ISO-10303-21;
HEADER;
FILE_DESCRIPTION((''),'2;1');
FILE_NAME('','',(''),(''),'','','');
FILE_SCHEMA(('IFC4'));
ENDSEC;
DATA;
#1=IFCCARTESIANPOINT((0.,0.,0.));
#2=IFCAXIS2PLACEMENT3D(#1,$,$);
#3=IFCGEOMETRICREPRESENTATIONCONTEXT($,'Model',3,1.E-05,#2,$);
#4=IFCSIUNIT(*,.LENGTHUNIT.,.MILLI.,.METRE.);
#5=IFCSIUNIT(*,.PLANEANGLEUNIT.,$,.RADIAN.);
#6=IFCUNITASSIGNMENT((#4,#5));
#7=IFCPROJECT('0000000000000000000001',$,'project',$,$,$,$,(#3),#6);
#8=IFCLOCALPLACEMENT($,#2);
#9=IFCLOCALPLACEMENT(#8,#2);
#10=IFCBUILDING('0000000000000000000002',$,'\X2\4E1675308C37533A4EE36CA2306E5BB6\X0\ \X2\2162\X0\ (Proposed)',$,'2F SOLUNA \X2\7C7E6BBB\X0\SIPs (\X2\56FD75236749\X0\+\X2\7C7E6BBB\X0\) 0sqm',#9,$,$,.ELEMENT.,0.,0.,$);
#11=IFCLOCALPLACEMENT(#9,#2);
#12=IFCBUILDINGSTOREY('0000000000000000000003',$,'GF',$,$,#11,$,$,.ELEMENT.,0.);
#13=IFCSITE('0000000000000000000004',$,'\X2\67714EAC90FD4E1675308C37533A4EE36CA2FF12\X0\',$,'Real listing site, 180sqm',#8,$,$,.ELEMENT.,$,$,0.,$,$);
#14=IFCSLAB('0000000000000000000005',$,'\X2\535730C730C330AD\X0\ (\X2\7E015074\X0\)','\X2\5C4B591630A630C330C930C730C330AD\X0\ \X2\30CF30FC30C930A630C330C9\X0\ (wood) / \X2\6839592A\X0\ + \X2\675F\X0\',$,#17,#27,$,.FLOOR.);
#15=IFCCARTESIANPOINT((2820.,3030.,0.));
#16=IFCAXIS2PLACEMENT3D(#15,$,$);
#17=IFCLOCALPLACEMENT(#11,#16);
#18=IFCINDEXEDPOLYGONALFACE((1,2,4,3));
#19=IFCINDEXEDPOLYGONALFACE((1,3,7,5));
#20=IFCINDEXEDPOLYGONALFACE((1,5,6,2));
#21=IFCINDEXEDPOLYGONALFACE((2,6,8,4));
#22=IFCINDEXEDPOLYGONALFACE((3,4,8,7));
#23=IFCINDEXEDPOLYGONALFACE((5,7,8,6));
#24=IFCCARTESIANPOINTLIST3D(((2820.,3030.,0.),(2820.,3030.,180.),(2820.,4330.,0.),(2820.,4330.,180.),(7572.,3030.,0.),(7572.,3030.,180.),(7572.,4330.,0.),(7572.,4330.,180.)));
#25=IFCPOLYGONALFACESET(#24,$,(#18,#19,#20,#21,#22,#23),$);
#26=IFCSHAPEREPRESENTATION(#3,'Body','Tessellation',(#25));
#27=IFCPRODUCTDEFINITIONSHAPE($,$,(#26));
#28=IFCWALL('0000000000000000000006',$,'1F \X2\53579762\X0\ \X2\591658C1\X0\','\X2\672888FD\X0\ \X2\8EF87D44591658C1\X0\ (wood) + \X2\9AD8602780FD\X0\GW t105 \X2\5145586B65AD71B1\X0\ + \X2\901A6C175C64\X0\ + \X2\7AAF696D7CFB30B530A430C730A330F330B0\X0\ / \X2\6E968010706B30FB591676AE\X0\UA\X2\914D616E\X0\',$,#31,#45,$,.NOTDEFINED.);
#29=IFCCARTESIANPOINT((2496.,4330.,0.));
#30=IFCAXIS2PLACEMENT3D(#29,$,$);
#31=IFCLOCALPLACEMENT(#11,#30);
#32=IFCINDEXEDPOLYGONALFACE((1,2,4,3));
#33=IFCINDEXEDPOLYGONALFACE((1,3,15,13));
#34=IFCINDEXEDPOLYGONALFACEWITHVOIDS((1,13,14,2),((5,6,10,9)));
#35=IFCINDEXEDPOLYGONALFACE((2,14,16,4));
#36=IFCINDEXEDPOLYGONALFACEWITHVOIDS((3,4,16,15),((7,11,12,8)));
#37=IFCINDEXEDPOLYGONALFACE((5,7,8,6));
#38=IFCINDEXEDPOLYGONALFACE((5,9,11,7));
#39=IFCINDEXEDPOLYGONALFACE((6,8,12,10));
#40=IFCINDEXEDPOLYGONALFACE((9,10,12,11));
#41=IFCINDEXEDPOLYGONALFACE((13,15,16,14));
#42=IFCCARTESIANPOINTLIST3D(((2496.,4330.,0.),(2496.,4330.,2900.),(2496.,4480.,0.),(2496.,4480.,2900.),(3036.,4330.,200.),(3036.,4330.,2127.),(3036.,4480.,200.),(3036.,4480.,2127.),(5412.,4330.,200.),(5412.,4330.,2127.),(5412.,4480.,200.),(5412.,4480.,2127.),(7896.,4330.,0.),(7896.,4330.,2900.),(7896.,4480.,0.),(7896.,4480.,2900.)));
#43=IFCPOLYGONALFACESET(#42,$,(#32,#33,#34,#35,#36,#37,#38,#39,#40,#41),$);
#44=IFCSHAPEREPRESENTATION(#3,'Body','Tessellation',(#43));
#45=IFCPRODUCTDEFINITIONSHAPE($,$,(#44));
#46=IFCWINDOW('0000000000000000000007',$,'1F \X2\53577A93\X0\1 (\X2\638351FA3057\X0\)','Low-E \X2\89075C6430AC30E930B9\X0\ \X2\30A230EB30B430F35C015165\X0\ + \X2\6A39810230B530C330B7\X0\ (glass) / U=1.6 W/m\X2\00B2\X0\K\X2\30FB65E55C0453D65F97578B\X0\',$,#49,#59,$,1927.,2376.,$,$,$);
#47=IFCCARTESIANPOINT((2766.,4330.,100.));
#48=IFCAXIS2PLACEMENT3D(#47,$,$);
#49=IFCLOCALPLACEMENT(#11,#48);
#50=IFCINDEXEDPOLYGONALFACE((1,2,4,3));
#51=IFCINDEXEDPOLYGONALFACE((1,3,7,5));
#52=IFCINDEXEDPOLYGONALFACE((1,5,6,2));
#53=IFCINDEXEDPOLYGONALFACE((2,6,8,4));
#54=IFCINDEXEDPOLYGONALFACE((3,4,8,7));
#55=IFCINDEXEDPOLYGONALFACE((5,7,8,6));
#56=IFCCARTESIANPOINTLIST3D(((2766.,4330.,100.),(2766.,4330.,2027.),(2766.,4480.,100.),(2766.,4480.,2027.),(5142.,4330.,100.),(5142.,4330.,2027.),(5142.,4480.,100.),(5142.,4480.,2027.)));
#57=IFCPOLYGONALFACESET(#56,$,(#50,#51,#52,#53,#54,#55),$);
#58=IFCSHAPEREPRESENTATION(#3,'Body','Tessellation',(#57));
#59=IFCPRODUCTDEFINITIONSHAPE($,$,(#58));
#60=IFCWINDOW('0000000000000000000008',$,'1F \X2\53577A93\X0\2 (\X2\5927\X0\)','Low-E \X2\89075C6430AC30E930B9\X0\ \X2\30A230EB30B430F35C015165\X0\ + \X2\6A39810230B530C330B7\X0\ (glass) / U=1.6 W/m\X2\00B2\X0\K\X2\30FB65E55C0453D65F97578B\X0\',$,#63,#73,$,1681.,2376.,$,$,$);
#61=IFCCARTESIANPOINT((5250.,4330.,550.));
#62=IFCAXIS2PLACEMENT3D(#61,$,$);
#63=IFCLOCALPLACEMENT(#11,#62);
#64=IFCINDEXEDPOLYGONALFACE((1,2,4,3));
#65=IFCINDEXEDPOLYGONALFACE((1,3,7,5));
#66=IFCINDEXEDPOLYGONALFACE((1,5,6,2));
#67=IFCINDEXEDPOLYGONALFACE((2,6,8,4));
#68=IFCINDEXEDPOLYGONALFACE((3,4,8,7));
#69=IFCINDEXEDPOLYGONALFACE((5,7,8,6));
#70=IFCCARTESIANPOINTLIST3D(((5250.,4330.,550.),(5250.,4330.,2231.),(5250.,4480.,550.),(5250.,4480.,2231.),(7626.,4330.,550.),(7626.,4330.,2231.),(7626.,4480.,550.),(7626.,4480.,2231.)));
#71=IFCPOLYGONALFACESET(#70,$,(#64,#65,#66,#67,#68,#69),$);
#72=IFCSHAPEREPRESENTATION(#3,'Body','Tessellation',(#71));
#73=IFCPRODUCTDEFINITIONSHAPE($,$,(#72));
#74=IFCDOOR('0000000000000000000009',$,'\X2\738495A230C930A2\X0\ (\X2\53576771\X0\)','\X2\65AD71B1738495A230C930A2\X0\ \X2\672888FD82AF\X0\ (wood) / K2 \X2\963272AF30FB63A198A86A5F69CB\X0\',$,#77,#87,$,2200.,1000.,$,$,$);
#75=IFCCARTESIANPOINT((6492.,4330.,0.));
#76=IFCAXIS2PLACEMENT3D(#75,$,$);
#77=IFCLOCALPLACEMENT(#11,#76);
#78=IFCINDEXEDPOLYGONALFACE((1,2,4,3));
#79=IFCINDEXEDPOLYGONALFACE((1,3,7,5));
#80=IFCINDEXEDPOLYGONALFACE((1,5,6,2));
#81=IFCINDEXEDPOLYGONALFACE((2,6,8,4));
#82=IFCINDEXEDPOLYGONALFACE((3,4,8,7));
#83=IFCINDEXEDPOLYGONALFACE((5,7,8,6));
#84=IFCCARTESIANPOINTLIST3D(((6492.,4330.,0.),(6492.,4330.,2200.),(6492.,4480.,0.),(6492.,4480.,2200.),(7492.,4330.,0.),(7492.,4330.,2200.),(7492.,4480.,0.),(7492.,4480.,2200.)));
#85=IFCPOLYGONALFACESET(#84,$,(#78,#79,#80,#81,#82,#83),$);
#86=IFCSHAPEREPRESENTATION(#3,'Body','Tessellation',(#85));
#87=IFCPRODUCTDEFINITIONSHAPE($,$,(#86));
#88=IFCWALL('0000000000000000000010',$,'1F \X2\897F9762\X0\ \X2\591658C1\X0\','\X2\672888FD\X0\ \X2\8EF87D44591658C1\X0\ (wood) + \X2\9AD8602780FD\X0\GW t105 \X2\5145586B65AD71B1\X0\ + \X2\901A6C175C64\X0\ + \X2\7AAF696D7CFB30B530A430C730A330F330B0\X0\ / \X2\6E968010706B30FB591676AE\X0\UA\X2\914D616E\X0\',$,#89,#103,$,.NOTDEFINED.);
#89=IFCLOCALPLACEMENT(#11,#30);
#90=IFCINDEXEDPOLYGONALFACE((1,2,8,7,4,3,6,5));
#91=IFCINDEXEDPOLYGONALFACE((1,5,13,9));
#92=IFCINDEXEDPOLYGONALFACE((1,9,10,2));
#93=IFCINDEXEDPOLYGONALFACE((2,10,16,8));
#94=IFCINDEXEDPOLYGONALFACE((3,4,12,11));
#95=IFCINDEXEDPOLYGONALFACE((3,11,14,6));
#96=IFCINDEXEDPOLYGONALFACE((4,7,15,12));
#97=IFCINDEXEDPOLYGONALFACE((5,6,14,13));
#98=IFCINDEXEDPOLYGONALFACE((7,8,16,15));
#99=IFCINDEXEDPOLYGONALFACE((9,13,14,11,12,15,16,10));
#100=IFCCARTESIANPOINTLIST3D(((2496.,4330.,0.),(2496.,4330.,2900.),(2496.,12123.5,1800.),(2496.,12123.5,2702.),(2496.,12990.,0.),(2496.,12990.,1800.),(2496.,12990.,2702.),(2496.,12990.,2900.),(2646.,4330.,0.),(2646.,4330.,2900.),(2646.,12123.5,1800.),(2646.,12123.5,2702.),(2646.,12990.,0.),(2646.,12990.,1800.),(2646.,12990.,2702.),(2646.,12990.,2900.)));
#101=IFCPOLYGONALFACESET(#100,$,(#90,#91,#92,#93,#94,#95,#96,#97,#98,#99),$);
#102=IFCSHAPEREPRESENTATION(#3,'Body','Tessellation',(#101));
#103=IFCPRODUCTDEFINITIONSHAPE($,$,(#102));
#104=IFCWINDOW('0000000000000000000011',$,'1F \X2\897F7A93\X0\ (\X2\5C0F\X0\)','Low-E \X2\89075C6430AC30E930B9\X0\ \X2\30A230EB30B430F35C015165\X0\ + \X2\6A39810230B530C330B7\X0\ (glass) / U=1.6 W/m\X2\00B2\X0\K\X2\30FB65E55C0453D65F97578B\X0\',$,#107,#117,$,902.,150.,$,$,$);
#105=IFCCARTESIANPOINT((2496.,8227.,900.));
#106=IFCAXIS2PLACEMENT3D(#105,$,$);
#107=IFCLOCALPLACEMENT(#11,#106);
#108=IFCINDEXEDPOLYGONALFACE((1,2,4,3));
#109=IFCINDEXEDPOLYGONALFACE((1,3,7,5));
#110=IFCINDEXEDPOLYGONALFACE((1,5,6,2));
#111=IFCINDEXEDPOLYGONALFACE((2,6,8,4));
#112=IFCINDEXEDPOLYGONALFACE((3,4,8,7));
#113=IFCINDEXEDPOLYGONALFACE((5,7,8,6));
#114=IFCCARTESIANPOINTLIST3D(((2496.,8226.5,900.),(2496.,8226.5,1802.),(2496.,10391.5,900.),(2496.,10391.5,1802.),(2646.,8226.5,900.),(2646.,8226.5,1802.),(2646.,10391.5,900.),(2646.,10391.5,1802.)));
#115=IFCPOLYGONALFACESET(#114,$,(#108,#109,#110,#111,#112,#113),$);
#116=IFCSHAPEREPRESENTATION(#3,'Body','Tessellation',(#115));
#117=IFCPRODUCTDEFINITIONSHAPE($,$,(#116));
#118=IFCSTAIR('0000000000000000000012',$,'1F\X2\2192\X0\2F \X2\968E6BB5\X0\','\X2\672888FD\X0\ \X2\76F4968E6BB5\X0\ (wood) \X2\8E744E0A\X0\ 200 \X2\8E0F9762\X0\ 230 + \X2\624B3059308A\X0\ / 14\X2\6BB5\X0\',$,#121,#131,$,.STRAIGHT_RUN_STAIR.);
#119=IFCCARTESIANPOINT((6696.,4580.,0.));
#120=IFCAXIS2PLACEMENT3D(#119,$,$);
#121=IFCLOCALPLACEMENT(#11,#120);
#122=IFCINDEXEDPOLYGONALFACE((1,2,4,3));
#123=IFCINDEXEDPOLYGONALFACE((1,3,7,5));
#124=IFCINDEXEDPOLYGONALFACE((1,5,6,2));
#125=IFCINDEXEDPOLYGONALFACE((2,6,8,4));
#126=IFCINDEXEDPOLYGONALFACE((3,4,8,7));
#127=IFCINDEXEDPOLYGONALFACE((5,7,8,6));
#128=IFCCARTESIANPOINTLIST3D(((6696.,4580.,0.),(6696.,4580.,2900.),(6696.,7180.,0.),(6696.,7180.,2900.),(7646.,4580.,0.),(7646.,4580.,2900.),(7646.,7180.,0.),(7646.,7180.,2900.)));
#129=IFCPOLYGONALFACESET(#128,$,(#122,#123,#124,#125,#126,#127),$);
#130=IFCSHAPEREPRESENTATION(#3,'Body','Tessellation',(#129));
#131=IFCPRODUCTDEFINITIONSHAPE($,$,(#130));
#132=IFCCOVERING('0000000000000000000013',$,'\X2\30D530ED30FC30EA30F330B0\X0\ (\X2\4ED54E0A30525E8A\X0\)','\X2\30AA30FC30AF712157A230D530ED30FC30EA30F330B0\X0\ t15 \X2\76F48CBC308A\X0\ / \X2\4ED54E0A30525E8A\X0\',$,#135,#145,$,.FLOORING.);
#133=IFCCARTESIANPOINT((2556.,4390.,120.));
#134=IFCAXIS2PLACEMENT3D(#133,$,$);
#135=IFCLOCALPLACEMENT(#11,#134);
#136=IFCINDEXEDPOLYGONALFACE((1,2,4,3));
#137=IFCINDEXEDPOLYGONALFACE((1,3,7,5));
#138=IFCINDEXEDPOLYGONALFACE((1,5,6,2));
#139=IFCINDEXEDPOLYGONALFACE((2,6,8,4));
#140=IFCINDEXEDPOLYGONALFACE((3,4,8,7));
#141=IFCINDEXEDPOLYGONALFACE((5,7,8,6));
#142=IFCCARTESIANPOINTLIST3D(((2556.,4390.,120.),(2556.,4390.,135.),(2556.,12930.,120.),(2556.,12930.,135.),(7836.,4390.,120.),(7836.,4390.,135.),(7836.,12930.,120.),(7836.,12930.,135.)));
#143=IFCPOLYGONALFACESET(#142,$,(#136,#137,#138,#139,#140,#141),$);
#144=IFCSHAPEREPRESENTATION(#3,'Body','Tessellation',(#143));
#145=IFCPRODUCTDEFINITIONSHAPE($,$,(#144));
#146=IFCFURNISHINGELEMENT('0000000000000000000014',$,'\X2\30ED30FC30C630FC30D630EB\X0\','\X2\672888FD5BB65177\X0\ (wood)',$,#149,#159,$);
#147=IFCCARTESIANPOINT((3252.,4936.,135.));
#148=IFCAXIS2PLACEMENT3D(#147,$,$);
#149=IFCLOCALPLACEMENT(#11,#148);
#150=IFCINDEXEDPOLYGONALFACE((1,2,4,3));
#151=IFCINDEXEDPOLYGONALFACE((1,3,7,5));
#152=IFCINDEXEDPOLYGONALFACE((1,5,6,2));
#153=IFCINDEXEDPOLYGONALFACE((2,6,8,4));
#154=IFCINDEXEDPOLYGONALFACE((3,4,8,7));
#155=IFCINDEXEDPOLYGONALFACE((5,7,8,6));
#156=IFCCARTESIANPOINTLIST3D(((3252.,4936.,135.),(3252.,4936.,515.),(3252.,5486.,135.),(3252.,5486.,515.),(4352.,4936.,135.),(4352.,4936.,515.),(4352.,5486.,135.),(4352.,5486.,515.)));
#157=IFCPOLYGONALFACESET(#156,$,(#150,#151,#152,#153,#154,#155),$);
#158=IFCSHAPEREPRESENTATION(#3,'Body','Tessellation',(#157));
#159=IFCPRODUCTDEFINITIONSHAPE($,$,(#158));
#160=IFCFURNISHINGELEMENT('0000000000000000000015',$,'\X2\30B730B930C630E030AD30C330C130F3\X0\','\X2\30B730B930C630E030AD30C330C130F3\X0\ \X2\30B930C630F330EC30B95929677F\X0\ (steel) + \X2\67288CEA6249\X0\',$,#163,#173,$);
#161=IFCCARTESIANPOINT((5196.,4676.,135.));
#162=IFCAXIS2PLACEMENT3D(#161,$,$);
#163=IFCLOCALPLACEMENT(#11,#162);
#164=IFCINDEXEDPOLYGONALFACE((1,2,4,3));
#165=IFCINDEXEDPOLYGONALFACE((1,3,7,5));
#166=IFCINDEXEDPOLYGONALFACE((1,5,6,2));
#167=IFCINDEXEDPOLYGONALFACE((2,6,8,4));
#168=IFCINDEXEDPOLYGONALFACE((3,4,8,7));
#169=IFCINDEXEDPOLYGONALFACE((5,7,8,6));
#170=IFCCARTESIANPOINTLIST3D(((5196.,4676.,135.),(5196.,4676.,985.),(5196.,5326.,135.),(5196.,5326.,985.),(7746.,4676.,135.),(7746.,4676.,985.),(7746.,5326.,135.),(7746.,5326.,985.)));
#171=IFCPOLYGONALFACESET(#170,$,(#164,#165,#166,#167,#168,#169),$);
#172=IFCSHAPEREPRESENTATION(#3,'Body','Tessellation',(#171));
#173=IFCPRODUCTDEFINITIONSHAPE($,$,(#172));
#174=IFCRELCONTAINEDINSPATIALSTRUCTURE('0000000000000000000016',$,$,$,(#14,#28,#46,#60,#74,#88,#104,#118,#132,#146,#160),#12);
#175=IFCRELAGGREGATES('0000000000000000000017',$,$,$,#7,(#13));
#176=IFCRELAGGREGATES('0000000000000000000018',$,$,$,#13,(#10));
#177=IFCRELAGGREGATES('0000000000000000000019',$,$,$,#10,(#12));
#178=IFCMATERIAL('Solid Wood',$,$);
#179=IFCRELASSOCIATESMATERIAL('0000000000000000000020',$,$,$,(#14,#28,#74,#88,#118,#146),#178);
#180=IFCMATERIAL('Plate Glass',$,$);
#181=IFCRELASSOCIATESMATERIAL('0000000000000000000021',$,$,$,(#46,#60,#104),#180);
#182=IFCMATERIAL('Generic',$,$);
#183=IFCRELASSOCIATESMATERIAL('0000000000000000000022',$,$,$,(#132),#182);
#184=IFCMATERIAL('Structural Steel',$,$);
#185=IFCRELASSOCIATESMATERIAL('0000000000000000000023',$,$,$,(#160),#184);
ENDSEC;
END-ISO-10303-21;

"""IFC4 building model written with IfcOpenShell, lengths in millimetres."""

from ifc_helpers import new_model, si_unit, frame, frame_2d, origin, place, context, project, spatial, rectangle, extrude, material, element, fill, save


model = new_model("IFC4")

# Units and contexts
model_context = context("Model", 3, precision=1e-05, world=origin())
ifc_project = project(units=[si_unit("LENGTHUNIT", "METRE", prefix="MILLI"), si_unit("PLANEANGLEUNIT", "RADIAN")], contexts=[model_context])

# Site, building, storey
site_placement = place(None, origin())
site = spatial("IfcSite", under=ifc_project, at=site_placement, Name="東京都世田谷区代沢２", ObjectType="Real listing site, 180sqm", CompositionType="ELEMENT", RefElevation=0.0)
building_placement = place(site_placement, origin())
building = spatial("IfcBuilding", under=site, at=building_placement, Name="世田谷区代沢の家 Ⅲ (Proposed)", ObjectType="2F SOLUNA 籾殻SIPs (国産杉+籾殻) 0sqm", CompositionType="ELEMENT", ElevationOfRefHeight=0.0, ElevationOfTerrain=0.0)
storey_placement = place(building_placement, origin())
storey = spatial("IfcBuildingStorey", under=building, at=storey_placement, Name="GF", CompositionType="ELEMENT", Elevation=0.0)

# Slab
ifc_material_1 = material(Name="Solid Wood")
slab_1_placement = place(storey_placement, frame((2820.0, 3030.0, 0.0)))
element("IfcSlab", 1, at=slab_1_placement, inside=storey, material=ifc_material_1, Name="南デッキ (縁側)", Description="屋外ウッドデッキ ハードウッド (wood) / 根太 + 束", PredefinedType="FLOOR", context=model_context, shape_type="SweptSolid", body=[
    extrude(rectangle(XDim=4752.0, YDim=1300.0, at=frame_2d((2376.0, 650.0))), frame((2820.0, 3030.0, 0.0)), (0.0, 0.0, 1.0), 180.0),
])

# Wall, openings, windows, door
wall_1_placement = place(storey_placement, frame((2496.0, 4330.0, 0.0)))
wall_1 = element("IfcWall", 2, at=wall_1_placement, inside=storey, material=ifc_material_1, Name="1F 南面 外壁", Description="木製 軸組外壁 (wood) + 高性能GW t105 充填断熱 + 通気層 + 窯業系サイディング / 準耐火・外皮UA配慮", PredefinedType="NOTDEFINED", context=model_context, shape_type="SweptSolid", body=[
    extrude(rectangle(XDim=5400.0, YDim=150.0, at=frame_2d((2700.0, 75.0))), frame((2496.0, 4330.0, 0.0)), (0.0, 0.0, 1.0), 2900.0),
])
opening_1_placement = place(storey_placement, frame((2766.0, 4330.0, 100.0)))
opening_1 = element("IfcOpeningElement", 3, at=opening_1_placement, cuts=wall_1, PredefinedType="NOTDEFINED", context=model_context, shape_type="SweptSolid", body=[
    extrude(rectangle(XDim=2376.0, YDim=150.0, at=frame_2d((1188.0, 75.0))), frame((2766.0, 4330.0, 100.0)), (0.0, 0.0, 1.0), 1927.0),
])
opening_2_placement = place(storey_placement, frame((5250.0, 4330.0, 550.0)))
opening_2 = element("IfcOpeningElement", 4, at=opening_2_placement, cuts=wall_1, PredefinedType="NOTDEFINED", context=model_context, shape_type="SweptSolid", body=[
    extrude(rectangle(XDim=2376.0, YDim=150.0, at=frame_2d((1188.0, 75.0))), frame((5250.0, 4330.0, 550.0)), (0.0, 0.0, 1.0), 1681.0),
])
opening_3_placement = place(storey_placement, frame((6492.0, 4330.0, 0.0)))
opening_3 = element("IfcOpeningElement", 5, at=opening_3_placement, cuts=wall_1, PredefinedType="NOTDEFINED", context=model_context, shape_type="SweptSolid", body=[
    extrude(rectangle(XDim=1000.0, YDim=150.0, at=frame_2d((500.0, 75.0))), frame((6492.0, 4330.0, 0.0)), (0.0, 0.0, 1.0), 2200.0),
])
ifc_material_2 = material(Name="Plate Glass")
window_1_placement = place(storey_placement, frame((2766.0, 4330.0, 100.0)))
window_1 = element("IfcWindow", 6, at=window_1_placement, inside=storey, material=ifc_material_2, Name="1F 南窓1 (掃出し)", Description="Low-E 複層ガラス アルゴン封入 + 樹脂サッシ (glass) / U=1.6 W/m²K・日射取得型", OverallHeight=1927.0, OverallWidth=2376.0, context=model_context, shape_type="SweptSolid", body=[
    extrude(rectangle(XDim=2376.0, YDim=150.0, at=frame_2d((1188.0, 75.0))), frame((2766.0, 4330.0, 100.0)), (0.0, 0.0, 1.0), 1927.0),
])
fill(opening_1, window_1)
window_2_placement = place(storey_placement, frame((5250.0, 4330.0, 550.0)))
window_2 = element("IfcWindow", 7, at=window_2_placement, inside=storey, material=ifc_material_2, Name="1F 南窓2 (大)", Description="Low-E 複層ガラス アルゴン封入 + 樹脂サッシ (glass) / U=1.6 W/m²K・日射取得型", OverallHeight=1681.0, OverallWidth=2376.0, context=model_context, shape_type="SweptSolid", body=[
    extrude(rectangle(XDim=2376.0, YDim=150.0, at=frame_2d((1188.0, 75.0))), frame((5250.0, 4330.0, 550.0)), (0.0, 0.0, 1.0), 1681.0),
])
fill(opening_2, window_2)
door_placement = place(storey_placement, frame((6492.0, 4330.0, 0.0)))
door = element("IfcDoor", 8, at=door_placement, inside=storey, material=ifc_material_1, Name="玄関ドア (南東)", Description="断熱玄関ドア 木製芯 (wood) / K2 防犯・採風機構", OverallHeight=2200.0, OverallWidth=1000.0, context=model_context, shape_type="SweptSolid", body=[
    extrude(rectangle(XDim=1000.0, YDim=150.0, at=frame_2d((500.0, 75.0))), frame((6492.0, 4330.0, 0.0)), (0.0, 0.0, 1.0), 2200.0),
])
fill(opening_3, door)

# Wall, opening, window
wall_2_placement = place(storey_placement, frame((2496.0, 4330.0, 0.0)))
wall_2 = element("IfcWall", 9, at=wall_2_placement, inside=storey, material=ifc_material_1, Name="1F 西面 外壁", Description="木製 軸組外壁 (wood) + 高性能GW t105 充填断熱 + 通気層 + 窯業系サイディング / 準耐火・外皮UA配慮", PredefinedType="NOTDEFINED", context=model_context, shape_type="SweptSolid", body=[
    extrude(rectangle(XDim=150.0, YDim=8660.0, at=frame_2d((75.0, 4330.0))), frame((2496.0, 4330.0, 0.0)), (0.0, 0.0, 1.0), 2900.0),
])
opening_4_placement = place(storey_placement, frame((2496.0, 8227.0, 900.0)))
opening_4 = element("IfcOpeningElement", 10, at=opening_4_placement, cuts=wall_2, PredefinedType="NOTDEFINED", context=model_context, shape_type="SweptSolid", body=[
    extrude(rectangle(XDim=150.0, YDim=2165.0, at=frame_2d((75.0, 1082.0))), frame((2496.0, 8227.0, 900.0)), (0.0, 0.0, 1.0), 902.0),
])
window_3_placement = place(storey_placement, frame((2496.0, 8227.0, 900.0)))
window_3 = element("IfcWindow", 11, at=window_3_placement, inside=storey, material=ifc_material_2, Name="1F 西窓 (小)", Description="Low-E 複層ガラス アルゴン封入 + 樹脂サッシ (glass) / U=1.6 W/m²K・日射取得型", OverallHeight=902.0, OverallWidth=150.0, context=model_context, shape_type="SweptSolid", body=[
    extrude(rectangle(XDim=150.0, YDim=2165.0, at=frame_2d((75.0, 1082.0))), frame((2496.0, 8227.0, 900.0)), (0.0, 0.0, 1.0), 902.0),
])
fill(opening_4, window_3)

# Stair
stair_placement = place(storey_placement, frame((6696.0, 4580.0, 0.0)))
element("IfcStair", 12, at=stair_placement, inside=storey, material=ifc_material_1, Name="1F→2F 階段", Description="木製 直階段 (wood) 蹴上 200 踏面 230 + 手すり / 14段", PredefinedType="STRAIGHT_RUN_STAIR", context=model_context, shape_type="SweptSolid", body=[
    extrude(rectangle(XDim=950.0, YDim=2600.0, at=frame_2d((475.0, 1300.0))), frame((6696.0, 4580.0, 0.0)), (0.0, 0.0, 1.0), 2900.0),
])

# Covering
ifc_material_3 = material(Name="Generic")
covering_placement = place(storey_placement, frame((2556.0, 4390.0, 120.0)))
element("IfcCovering", 13, at=covering_placement, inside=storey, material=ifc_material_3, Name="フローリング (仕上げ床)", Description="オーク無垢フローリング t15 直貼り / 仕上げ床", PredefinedType="FLOORING", context=model_context, shape_type="SweptSolid", body=[
    extrude(rectangle(XDim=5280.0, YDim=8540.0, at=frame_2d((2640.0, 4270.0))), frame((2556.0, 4390.0, 120.0)), (0.0, 0.0, 1.0), 15.0),
])

# Furnishing elements
furnishing_1_placement = place(storey_placement, frame((3252.0, 4936.0, 135.0)))
element("IfcFurnishingElement", 14, at=furnishing_1_placement, inside=storey, material=ifc_material_1, Name="ローテーブル", Description="木製家具 (wood)", context=model_context, shape_type="SweptSolid", body=[
    extrude(rectangle(XDim=1100.0, YDim=550.0, at=frame_2d((550.0, 275.0))), frame((3252.0, 4936.0, 135.0)), (0.0, 0.0, 1.0), 380.0),
])
ifc_material_4 = material(Name="Structural Steel")
furnishing_2_placement = place(storey_placement, frame((5196.0, 4676.0, 135.0)))
element("IfcFurnishingElement", 15, at=furnishing_2_placement, inside=storey, material=ifc_material_4, Name="システムキッチン", Description="システムキッチン ステンレス天板 (steel) + 木質扉", context=model_context, shape_type="SweptSolid", body=[
    extrude(rectangle(XDim=2550.0, YDim=650.0, at=frame_2d((1275.0, 325.0))), frame((5196.0, 4676.0, 135.0)), (0.0, 0.0, 1.0), 850.0),
])

save(model, "model.ifc")
